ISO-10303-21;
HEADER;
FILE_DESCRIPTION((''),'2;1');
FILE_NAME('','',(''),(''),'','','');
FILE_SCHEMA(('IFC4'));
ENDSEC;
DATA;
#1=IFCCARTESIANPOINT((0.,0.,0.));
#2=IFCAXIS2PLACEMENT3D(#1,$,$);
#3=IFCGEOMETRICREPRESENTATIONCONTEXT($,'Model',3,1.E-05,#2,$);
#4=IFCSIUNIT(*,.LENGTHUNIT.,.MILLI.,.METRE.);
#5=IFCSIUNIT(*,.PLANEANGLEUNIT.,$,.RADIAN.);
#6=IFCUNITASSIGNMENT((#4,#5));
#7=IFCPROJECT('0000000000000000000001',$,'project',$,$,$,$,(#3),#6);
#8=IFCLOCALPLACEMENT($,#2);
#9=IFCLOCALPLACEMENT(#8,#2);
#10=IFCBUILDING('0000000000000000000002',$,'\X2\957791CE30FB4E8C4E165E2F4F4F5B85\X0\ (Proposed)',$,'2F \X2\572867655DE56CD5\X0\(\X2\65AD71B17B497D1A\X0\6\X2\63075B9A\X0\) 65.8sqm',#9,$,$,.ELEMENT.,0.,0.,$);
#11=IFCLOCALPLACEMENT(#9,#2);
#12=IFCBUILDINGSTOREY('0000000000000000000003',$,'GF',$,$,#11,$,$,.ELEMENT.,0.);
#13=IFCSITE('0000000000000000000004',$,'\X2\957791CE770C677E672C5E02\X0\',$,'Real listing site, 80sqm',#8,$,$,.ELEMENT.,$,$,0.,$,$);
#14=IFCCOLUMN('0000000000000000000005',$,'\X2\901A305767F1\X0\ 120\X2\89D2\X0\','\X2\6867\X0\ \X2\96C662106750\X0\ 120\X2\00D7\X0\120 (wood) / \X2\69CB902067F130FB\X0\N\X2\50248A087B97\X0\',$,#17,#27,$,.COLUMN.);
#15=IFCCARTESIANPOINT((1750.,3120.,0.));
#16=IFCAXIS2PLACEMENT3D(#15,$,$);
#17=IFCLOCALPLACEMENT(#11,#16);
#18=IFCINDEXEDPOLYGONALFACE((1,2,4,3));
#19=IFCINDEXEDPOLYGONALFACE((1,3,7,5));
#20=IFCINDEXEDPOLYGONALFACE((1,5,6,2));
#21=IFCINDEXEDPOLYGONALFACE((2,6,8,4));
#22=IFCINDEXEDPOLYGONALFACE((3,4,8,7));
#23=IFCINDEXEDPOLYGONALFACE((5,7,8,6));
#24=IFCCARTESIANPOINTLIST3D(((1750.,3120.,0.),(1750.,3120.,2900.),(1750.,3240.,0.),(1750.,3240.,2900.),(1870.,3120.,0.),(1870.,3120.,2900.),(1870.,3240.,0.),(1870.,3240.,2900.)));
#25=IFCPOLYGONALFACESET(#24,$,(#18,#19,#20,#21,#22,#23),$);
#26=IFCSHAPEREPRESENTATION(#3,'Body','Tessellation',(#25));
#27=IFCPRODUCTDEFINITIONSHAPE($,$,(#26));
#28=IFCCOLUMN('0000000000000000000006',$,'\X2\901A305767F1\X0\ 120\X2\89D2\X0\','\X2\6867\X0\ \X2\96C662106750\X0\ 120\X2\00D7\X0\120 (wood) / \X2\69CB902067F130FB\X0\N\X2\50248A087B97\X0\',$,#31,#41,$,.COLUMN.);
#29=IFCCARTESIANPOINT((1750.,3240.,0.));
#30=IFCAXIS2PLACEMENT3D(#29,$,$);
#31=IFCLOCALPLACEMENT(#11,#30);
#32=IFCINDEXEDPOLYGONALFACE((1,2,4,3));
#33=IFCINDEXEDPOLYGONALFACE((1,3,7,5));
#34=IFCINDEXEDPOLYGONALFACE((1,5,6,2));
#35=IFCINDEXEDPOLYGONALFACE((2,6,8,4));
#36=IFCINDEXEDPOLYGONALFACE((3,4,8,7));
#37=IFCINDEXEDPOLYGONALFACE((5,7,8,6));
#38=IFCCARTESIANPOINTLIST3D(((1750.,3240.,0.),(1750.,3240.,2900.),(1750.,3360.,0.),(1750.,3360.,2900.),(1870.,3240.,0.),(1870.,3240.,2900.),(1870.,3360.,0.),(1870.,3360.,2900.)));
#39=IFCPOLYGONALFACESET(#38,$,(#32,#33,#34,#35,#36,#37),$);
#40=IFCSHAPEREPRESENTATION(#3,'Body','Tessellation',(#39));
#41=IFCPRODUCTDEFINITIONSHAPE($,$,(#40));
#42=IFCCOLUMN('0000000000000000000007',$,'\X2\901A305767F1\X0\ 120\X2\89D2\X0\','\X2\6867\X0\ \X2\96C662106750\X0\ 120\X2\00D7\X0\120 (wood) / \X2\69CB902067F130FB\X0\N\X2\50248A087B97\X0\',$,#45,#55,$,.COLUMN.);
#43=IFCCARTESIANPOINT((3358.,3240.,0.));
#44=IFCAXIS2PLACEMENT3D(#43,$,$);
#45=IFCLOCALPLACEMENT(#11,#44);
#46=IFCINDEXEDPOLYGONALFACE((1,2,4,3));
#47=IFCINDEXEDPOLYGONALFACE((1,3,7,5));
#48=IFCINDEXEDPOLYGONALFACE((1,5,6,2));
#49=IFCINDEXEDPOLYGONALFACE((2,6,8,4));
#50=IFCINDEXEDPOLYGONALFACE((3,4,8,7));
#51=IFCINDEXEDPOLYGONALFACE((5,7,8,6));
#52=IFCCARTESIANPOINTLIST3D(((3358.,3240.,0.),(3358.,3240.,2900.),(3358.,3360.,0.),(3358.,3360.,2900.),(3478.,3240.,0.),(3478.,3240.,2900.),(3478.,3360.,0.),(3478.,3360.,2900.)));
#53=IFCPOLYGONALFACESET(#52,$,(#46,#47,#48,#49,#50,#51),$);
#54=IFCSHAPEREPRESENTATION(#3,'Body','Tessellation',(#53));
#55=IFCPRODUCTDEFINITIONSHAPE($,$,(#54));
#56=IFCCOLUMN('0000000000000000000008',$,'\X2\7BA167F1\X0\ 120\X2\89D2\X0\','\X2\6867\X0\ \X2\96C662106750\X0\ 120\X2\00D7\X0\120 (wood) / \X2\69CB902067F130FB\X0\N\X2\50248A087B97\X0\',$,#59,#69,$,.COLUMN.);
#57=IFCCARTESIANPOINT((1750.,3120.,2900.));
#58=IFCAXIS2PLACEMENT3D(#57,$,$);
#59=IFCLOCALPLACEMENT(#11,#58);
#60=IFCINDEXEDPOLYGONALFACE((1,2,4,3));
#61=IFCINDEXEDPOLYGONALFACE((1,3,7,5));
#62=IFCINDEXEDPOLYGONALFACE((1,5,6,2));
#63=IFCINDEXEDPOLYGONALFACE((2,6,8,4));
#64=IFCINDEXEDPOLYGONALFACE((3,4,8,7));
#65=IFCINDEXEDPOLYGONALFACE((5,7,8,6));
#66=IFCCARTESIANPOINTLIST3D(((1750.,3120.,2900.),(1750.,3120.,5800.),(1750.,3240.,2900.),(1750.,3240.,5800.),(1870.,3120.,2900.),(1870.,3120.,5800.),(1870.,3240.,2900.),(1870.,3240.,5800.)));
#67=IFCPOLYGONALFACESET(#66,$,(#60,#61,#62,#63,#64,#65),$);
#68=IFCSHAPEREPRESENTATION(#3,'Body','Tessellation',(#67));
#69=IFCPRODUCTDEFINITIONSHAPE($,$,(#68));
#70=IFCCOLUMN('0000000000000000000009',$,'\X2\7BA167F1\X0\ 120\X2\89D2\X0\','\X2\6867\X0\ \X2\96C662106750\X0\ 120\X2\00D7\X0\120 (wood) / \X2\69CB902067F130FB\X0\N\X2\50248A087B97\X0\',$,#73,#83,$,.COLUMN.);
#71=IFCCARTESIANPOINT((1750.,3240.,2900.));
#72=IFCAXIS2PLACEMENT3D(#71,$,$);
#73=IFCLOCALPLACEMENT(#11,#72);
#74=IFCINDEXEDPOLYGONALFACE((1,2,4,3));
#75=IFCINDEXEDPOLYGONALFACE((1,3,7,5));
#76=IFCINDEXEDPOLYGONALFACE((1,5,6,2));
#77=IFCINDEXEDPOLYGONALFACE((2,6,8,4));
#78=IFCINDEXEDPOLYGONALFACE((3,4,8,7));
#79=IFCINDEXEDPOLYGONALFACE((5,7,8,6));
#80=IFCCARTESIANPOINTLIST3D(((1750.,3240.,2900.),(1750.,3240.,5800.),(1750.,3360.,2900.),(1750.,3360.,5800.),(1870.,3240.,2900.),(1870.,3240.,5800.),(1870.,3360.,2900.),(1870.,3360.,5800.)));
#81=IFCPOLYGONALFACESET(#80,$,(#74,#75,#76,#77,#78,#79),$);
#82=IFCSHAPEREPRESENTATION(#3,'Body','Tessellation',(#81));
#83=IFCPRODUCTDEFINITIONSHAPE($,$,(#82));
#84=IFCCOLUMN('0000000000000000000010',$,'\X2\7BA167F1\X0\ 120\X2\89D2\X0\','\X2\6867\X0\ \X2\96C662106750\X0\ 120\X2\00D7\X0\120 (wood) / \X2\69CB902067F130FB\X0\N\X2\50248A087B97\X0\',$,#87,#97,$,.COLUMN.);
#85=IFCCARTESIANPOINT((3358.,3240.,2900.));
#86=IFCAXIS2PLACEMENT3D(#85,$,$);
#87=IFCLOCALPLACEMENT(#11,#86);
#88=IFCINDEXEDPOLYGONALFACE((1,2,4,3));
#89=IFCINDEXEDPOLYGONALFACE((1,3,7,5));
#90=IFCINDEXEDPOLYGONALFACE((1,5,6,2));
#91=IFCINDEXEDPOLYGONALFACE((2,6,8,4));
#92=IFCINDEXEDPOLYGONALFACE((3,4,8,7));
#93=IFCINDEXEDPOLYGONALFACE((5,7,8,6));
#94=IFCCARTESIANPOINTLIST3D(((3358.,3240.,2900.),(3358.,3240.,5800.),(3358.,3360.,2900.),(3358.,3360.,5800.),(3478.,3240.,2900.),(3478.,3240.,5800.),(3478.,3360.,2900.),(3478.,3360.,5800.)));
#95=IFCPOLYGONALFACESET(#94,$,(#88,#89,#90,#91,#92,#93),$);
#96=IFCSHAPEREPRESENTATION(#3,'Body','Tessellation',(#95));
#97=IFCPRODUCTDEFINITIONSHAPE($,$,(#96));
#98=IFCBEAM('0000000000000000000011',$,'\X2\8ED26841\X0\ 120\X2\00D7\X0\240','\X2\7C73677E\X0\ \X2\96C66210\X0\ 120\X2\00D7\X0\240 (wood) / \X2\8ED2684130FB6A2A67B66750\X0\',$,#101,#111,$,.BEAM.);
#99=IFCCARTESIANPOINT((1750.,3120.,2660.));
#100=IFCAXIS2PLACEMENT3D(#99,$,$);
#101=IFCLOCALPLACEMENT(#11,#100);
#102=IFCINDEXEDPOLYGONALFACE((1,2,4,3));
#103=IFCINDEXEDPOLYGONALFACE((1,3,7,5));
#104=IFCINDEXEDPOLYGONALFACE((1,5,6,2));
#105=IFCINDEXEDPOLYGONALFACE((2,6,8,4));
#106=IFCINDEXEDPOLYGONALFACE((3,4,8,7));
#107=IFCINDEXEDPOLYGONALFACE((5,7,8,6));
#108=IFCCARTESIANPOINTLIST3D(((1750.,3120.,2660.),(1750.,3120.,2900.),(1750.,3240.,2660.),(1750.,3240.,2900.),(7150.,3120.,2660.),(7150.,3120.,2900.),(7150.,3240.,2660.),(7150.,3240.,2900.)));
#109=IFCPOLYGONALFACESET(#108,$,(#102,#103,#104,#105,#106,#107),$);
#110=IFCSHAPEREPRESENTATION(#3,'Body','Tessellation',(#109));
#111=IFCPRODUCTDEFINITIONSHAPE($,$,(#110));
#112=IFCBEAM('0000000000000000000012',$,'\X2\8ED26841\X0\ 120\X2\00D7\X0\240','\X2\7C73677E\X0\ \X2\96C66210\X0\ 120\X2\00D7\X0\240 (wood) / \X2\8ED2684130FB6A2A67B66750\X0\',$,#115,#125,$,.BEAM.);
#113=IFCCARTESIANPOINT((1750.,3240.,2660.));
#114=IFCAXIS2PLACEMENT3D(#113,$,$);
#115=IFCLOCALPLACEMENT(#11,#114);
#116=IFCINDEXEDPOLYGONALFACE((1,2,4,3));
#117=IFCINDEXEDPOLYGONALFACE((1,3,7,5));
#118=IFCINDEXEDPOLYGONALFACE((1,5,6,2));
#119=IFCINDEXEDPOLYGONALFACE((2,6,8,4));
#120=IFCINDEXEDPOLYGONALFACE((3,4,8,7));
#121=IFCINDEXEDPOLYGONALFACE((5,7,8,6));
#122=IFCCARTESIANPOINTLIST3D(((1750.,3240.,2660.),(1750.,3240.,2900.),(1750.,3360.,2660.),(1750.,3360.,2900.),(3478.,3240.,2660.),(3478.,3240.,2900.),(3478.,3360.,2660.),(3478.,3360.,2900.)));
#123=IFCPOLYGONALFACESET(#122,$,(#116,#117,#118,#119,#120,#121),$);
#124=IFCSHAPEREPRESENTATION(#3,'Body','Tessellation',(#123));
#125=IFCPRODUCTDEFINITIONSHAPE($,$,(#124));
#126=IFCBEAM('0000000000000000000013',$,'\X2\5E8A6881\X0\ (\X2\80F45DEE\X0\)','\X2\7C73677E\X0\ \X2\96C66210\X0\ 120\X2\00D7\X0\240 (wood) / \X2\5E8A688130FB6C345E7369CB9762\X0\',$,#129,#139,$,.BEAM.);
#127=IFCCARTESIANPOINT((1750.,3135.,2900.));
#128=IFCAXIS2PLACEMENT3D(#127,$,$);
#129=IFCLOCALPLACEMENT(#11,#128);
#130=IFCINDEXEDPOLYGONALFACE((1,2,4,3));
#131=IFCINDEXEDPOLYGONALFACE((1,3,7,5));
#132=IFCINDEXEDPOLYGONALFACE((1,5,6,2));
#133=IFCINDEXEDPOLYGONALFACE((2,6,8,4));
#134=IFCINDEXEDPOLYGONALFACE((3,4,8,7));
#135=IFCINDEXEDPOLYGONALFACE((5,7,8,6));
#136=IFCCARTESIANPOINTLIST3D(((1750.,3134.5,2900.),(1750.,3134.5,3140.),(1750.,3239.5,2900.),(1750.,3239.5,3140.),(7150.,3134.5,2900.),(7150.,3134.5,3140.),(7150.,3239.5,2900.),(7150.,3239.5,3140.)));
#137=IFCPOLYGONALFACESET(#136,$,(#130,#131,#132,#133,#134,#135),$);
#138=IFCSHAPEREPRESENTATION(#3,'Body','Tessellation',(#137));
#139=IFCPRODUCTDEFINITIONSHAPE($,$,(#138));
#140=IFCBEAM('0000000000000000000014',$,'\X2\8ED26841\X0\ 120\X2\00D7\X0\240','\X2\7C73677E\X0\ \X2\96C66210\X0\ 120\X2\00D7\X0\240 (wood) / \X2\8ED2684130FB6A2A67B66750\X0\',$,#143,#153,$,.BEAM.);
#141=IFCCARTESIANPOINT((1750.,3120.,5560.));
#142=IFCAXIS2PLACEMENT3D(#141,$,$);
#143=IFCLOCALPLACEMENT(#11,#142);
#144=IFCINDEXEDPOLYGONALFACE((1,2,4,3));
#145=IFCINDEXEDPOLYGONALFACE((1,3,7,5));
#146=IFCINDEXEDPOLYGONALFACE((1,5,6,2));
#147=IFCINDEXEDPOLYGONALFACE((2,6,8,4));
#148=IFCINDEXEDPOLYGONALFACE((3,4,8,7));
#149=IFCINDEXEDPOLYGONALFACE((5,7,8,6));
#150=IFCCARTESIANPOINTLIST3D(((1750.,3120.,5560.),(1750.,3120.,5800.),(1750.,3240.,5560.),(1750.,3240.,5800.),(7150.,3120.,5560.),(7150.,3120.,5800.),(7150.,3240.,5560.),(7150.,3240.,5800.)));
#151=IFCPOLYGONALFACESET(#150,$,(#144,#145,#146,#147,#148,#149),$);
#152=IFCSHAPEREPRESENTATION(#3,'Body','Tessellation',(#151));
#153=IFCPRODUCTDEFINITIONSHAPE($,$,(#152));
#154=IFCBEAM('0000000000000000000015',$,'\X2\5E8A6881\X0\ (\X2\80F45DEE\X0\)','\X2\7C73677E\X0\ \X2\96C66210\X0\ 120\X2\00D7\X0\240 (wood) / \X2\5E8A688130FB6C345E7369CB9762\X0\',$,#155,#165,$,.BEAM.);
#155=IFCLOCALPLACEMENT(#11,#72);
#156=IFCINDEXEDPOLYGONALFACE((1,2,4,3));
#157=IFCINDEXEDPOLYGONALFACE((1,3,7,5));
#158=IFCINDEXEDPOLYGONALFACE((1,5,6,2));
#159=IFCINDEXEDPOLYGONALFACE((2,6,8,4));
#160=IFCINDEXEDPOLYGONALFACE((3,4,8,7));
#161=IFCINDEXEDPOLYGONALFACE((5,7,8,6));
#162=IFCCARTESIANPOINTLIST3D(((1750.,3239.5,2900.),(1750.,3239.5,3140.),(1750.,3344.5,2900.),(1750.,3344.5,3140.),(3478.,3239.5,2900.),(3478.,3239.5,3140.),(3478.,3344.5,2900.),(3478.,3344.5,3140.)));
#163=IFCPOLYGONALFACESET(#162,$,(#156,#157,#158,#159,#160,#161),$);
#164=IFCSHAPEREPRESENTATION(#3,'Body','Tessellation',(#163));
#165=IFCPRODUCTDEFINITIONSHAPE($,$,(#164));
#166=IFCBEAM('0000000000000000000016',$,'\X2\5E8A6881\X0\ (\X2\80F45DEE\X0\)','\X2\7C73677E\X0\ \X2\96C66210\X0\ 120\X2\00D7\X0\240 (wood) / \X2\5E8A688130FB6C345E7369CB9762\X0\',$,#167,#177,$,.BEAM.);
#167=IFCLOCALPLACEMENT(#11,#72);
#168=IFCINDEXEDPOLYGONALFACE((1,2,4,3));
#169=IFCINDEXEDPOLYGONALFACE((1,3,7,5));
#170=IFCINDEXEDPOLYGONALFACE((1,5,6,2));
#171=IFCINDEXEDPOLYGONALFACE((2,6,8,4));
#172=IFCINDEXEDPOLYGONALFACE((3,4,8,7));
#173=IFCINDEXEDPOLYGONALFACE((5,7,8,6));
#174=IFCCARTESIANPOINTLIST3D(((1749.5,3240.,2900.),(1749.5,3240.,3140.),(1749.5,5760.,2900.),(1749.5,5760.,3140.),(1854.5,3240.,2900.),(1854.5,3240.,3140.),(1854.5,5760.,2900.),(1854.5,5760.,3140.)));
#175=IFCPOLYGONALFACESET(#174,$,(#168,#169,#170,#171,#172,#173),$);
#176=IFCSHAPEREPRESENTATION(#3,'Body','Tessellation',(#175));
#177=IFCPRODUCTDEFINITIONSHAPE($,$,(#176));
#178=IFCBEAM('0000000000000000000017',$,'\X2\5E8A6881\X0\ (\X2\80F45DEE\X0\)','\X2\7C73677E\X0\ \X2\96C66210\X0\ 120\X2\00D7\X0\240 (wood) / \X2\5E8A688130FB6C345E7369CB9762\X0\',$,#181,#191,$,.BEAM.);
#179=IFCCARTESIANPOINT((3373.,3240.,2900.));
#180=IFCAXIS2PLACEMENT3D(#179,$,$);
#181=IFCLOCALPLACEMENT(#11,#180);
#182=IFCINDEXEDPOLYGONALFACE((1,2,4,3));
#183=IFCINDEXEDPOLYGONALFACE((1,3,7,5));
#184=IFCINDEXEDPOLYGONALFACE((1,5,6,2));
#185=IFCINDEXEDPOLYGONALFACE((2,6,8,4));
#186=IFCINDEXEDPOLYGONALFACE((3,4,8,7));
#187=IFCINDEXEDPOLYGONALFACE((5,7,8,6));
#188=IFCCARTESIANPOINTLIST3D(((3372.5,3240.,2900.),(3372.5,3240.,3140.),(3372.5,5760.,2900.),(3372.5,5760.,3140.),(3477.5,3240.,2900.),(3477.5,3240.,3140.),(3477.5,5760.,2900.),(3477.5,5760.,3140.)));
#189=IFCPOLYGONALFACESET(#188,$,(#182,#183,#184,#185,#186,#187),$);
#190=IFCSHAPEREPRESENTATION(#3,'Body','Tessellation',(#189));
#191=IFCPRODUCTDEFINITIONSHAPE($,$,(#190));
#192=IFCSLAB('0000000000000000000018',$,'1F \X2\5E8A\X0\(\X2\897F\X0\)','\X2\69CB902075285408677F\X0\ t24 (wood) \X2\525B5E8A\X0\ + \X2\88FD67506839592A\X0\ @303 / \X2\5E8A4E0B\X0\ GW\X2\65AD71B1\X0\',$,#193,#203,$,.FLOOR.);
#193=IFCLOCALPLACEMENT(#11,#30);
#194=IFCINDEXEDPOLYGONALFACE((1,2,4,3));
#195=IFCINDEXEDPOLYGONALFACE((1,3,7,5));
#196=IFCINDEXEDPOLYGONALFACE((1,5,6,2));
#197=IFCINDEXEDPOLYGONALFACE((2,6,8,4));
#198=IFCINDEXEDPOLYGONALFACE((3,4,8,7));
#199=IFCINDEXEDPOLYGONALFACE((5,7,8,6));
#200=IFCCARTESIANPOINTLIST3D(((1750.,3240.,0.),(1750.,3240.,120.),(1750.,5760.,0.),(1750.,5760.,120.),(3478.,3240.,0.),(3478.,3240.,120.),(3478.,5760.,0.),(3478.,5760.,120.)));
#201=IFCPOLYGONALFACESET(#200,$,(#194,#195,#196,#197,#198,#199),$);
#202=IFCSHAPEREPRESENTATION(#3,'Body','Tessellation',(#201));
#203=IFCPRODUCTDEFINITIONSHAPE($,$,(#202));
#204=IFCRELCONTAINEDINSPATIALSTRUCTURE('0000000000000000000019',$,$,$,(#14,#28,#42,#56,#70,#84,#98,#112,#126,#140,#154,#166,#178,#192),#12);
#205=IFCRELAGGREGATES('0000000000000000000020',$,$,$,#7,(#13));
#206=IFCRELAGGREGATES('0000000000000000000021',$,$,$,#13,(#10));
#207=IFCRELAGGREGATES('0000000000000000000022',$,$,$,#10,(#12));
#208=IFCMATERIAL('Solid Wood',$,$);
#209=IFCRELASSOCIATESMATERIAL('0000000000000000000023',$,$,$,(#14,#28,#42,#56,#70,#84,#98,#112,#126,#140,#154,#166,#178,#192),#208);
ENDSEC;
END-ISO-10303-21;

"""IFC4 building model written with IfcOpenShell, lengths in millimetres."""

from ifc_helpers import new_model, si_unit, frame, frame_2d, origin, place, context, project, spatial, rectangle, extrude, material, element, save


model = new_model("IFC4")

# Units and contexts
model_context = context("Model", 3, precision=1e-05, world=origin())
ifc_project = project(units=[si_unit("LENGTHUNIT", "METRE", prefix="MILLI"), si_unit("PLANEANGLEUNIT", "RADIAN")], contexts=[model_context])

# Site, building, storey
site_placement = place(None, origin())
site = spatial("IfcSite", under=ifc_project, at=site_placement, Name="長野県松本市", ObjectType="Real listing site, 80sqm", CompositionType="ELEMENT", RefElevation=0.0)
building_placement = place(site_placement, origin())
building = spatial("IfcBuilding", under=site, at=building_placement, Name="長野・二世帯住宅 (Proposed)", ObjectType="2F 在来工法(断熱等級6指定) 65.8sqm", CompositionType="ELEMENT", ElevationOfRefHeight=0.0, ElevationOfTerrain=0.0)
storey_placement = place(building_placement, origin())
storey = spatial("IfcBuildingStorey", under=building, at=storey_placement, Name="GF", CompositionType="ELEMENT", Elevation=0.0)

# Columns
ifc_material_1 = material(Name="Solid Wood")
column_1_placement = place(storey_placement, frame((1750.0, 3120.0, 0.0)))
element("IfcColumn", 1, at=column_1_placement, inside=storey, material=ifc_material_1, Name="通し柱 120角", Description="桧 集成材 120×120 (wood) / 構造柱・N値計算", PredefinedType="COLUMN", context=model_context, shape_type="SweptSolid", body=[
    extrude(rectangle(XDim=120.0, YDim=120.0, at=frame_2d((60.0, 60.0))), frame((1750.0, 3120.0, 0.0)), (0.0, 0.0, 1.0), 2900.0),
])
column_2_placement = place(storey_placement, frame((1750.0, 3240.0, 0.0)))
element("IfcColumn", 2, at=column_2_placement, inside=storey, material=ifc_material_1, Name="通し柱 120角", Description="桧 集成材 120×120 (wood) / 構造柱・N値計算", PredefinedType="COLUMN", context=model_context, shape_type="SweptSolid", body=[
    extrude(rectangle(XDim=120.0, YDim=120.0, at=frame_2d((60.0, 60.0))), frame((1750.0, 3240.0, 0.0)), (0.0, 0.0, 1.0), 2900.0),
])
column_3_placement = place(storey_placement, frame((3358.0, 3240.0, 0.0)))
element("IfcColumn", 3, at=column_3_placement, inside=storey, material=ifc_material_1, Name="通し柱 120角", Description="桧 集成材 120×120 (wood) / 構造柱・N値計算", PredefinedType="COLUMN", context=model_context, shape_type="SweptSolid", body=[
    extrude(rectangle(XDim=120.0, YDim=120.0, at=frame_2d((60.0, 60.0))), frame((3358.0, 3240.0, 0.0)), (0.0, 0.0, 1.0), 2900.0),
])
column_4_placement = place(storey_placement, frame((1750.0, 3120.0, 2900.0)))
element("IfcColumn", 4, at=column_4_placement, inside=storey, material=ifc_material_1, Name="管柱 120角", Description="桧 集成材 120×120 (wood) / 構造柱・N値計算", PredefinedType="COLUMN", context=model_context, shape_type="SweptSolid", body=[
    extrude(rectangle(XDim=120.0, YDim=120.0, at=frame_2d((60.0, 60.0))), frame((1750.0, 3120.0, 2900.0)), (0.0, 0.0, 1.0), 2900.0),
])
column_5_placement = place(storey_placement, frame((1750.0, 3240.0, 2900.0)))
element("IfcColumn", 5, at=column_5_placement, inside=storey, material=ifc_material_1, Name="管柱 120角", Description="桧 集成材 120×120 (wood) / 構造柱・N値計算", PredefinedType="COLUMN", context=model_context, shape_type="SweptSolid", body=[
    extrude(rectangle(XDim=120.0, YDim=120.0, at=frame_2d((60.0, 60.0))), frame((1750.0, 3240.0, 2900.0)), (0.0, 0.0, 1.0), 2900.0),
])
column_6_placement = place(storey_placement, frame((3358.0, 3240.0, 2900.0)))
element("IfcColumn", 6, at=column_6_placement, inside=storey, material=ifc_material_1, Name="管柱 120角", Description="桧 集成材 120×120 (wood) / 構造柱・N値計算", PredefinedType="COLUMN", context=model_context, shape_type="SweptSolid", body=[
    extrude(rectangle(XDim=120.0, YDim=120.0, at=frame_2d((60.0, 60.0))), frame((3358.0, 3240.0, 2900.0)), (0.0, 0.0, 1.0), 2900.0),
])

# Beams
beam_1_placement = place(storey_placement, frame((1750.0, 3120.0, 2660.0)))
element("IfcBeam", 7, at=beam_1_placement, inside=storey, material=ifc_material_1, Name="軒桁 120×240", Description="米松 集成 120×240 (wood) / 軒桁・横架材", PredefinedType="BEAM", context=model_context, shape_type="SweptSolid", body=[
    extrude(rectangle(XDim=5400.0, YDim=120.0, at=frame_2d((2700.0, 60.0))), frame((1750.0, 3120.0, 2660.0)), (0.0, 0.0, 1.0), 240.0),
])
beam_2_placement = place(storey_placement, frame((1750.0, 3240.0, 2660.0)))
element("IfcBeam", 8, at=beam_2_placement, inside=storey, material=ifc_material_1, Name="軒桁 120×240", Description="米松 集成 120×240 (wood) / 軒桁・横架材", PredefinedType="BEAM", context=model_context, shape_type="SweptSolid", body=[
    extrude(rectangle(XDim=1728.0, YDim=120.0, at=frame_2d((864.0, 60.0))), frame((1750.0, 3240.0, 2660.0)), (0.0, 0.0, 1.0), 240.0),
])
beam_3_placement = place(storey_placement, frame((1750.0, 3135.0, 2900.0)))
element("IfcBeam", 9, at=beam_3_placement, inside=storey, material=ifc_material_1, Name="床梁 (胴差)", Description="米松 集成 120×240 (wood) / 床梁・水平構面", PredefinedType="BEAM", context=model_context, shape_type="SweptSolid", body=[
    extrude(rectangle(XDim=5400.0, YDim=105.0, at=frame_2d((2700.0, 52.0))), frame((1750.0, 3135.0, 2900.0)), (0.0, 0.0, 1.0), 240.0),
])
beam_4_placement = place(storey_placement, frame((1750.0, 3120.0, 5560.0)))
element("IfcBeam", 10, at=beam_4_placement, inside=storey, material=ifc_material_1, Name="軒桁 120×240", Description="米松 集成 120×240 (wood) / 軒桁・横架材", PredefinedType="BEAM", context=model_context, shape_type="SweptSolid", body=[
    extrude(rectangle(XDim=5400.0, YDim=120.0, at=frame_2d((2700.0, 60.0))), frame((1750.0, 3120.0, 5560.0)), (0.0, 0.0, 1.0), 240.0),
])
beam_5_placement = place(storey_placement, frame((1750.0, 3240.0, 2900.0)))
element("IfcBeam", 11, at=beam_5_placement, inside=storey, material=ifc_material_1, Name="床梁 (胴差)", Description="米松 集成 120×240 (wood) / 床梁・水平構面", PredefinedType="BEAM", context=model_context, shape_type="SweptSolid", body=[
    extrude(rectangle(XDim=1728.0, YDim=105.0, at=frame_2d((864.0, 52.0))), frame((1750.0, 3240.0, 2900.0)), (0.0, 0.0, 1.0), 240.0),
])
beam_6_placement = place(storey_placement, frame((1750.0, 3240.0, 2900.0)))
element("IfcBeam", 12, at=beam_6_placement, inside=storey, material=ifc_material_1, Name="床梁 (胴差)", Description="米松 集成 120×240 (wood) / 床梁・水平構面", PredefinedType="BEAM", context=model_context, shape_type="SweptSolid", body=[
    extrude(rectangle(XDim=105.0, YDim=2520.0, at=frame_2d((52.0, 1260.0))), frame((1750.0, 3240.0, 2900.0)), (0.0, 0.0, 1.0), 240.0),
])
beam_7_placement = place(storey_placement, frame((3373.0, 3240.0, 2900.0)))
element("IfcBeam", 13, at=beam_7_placement, inside=storey, material=ifc_material_1, Name="床梁 (胴差)", Description="米松 集成 120×240 (wood) / 床梁・水平構面", PredefinedType="BEAM", context=model_context, shape_type="SweptSolid", body=[
    extrude(rectangle(XDim=105.0, YDim=2520.0, at=frame_2d((52.0, 1260.0))), frame((3373.0, 3240.0, 2900.0)), (0.0, 0.0, 1.0), 240.0),
])

# Slab
slab_1_placement = place(storey_placement, frame((1750.0, 3240.0, 0.0)))
element("IfcSlab", 14, at=slab_1_placement, inside=storey, material=ifc_material_1, Name="1F 床(西)", Description="構造用合板 t24 (wood) 剛床 + 製材根太 @303 / 床下 GW断熱", PredefinedType="FLOOR", context=model_context, shape_type="SweptSolid", body=[
    extrude(rectangle(XDim=1728.0, YDim=2520.0, at=frame_2d((864.0, 1260.0))), frame((1750.0, 3240.0, 0.0)), (0.0, 0.0, 1.0), 120.0),
])

save(model, "model.ifc")
